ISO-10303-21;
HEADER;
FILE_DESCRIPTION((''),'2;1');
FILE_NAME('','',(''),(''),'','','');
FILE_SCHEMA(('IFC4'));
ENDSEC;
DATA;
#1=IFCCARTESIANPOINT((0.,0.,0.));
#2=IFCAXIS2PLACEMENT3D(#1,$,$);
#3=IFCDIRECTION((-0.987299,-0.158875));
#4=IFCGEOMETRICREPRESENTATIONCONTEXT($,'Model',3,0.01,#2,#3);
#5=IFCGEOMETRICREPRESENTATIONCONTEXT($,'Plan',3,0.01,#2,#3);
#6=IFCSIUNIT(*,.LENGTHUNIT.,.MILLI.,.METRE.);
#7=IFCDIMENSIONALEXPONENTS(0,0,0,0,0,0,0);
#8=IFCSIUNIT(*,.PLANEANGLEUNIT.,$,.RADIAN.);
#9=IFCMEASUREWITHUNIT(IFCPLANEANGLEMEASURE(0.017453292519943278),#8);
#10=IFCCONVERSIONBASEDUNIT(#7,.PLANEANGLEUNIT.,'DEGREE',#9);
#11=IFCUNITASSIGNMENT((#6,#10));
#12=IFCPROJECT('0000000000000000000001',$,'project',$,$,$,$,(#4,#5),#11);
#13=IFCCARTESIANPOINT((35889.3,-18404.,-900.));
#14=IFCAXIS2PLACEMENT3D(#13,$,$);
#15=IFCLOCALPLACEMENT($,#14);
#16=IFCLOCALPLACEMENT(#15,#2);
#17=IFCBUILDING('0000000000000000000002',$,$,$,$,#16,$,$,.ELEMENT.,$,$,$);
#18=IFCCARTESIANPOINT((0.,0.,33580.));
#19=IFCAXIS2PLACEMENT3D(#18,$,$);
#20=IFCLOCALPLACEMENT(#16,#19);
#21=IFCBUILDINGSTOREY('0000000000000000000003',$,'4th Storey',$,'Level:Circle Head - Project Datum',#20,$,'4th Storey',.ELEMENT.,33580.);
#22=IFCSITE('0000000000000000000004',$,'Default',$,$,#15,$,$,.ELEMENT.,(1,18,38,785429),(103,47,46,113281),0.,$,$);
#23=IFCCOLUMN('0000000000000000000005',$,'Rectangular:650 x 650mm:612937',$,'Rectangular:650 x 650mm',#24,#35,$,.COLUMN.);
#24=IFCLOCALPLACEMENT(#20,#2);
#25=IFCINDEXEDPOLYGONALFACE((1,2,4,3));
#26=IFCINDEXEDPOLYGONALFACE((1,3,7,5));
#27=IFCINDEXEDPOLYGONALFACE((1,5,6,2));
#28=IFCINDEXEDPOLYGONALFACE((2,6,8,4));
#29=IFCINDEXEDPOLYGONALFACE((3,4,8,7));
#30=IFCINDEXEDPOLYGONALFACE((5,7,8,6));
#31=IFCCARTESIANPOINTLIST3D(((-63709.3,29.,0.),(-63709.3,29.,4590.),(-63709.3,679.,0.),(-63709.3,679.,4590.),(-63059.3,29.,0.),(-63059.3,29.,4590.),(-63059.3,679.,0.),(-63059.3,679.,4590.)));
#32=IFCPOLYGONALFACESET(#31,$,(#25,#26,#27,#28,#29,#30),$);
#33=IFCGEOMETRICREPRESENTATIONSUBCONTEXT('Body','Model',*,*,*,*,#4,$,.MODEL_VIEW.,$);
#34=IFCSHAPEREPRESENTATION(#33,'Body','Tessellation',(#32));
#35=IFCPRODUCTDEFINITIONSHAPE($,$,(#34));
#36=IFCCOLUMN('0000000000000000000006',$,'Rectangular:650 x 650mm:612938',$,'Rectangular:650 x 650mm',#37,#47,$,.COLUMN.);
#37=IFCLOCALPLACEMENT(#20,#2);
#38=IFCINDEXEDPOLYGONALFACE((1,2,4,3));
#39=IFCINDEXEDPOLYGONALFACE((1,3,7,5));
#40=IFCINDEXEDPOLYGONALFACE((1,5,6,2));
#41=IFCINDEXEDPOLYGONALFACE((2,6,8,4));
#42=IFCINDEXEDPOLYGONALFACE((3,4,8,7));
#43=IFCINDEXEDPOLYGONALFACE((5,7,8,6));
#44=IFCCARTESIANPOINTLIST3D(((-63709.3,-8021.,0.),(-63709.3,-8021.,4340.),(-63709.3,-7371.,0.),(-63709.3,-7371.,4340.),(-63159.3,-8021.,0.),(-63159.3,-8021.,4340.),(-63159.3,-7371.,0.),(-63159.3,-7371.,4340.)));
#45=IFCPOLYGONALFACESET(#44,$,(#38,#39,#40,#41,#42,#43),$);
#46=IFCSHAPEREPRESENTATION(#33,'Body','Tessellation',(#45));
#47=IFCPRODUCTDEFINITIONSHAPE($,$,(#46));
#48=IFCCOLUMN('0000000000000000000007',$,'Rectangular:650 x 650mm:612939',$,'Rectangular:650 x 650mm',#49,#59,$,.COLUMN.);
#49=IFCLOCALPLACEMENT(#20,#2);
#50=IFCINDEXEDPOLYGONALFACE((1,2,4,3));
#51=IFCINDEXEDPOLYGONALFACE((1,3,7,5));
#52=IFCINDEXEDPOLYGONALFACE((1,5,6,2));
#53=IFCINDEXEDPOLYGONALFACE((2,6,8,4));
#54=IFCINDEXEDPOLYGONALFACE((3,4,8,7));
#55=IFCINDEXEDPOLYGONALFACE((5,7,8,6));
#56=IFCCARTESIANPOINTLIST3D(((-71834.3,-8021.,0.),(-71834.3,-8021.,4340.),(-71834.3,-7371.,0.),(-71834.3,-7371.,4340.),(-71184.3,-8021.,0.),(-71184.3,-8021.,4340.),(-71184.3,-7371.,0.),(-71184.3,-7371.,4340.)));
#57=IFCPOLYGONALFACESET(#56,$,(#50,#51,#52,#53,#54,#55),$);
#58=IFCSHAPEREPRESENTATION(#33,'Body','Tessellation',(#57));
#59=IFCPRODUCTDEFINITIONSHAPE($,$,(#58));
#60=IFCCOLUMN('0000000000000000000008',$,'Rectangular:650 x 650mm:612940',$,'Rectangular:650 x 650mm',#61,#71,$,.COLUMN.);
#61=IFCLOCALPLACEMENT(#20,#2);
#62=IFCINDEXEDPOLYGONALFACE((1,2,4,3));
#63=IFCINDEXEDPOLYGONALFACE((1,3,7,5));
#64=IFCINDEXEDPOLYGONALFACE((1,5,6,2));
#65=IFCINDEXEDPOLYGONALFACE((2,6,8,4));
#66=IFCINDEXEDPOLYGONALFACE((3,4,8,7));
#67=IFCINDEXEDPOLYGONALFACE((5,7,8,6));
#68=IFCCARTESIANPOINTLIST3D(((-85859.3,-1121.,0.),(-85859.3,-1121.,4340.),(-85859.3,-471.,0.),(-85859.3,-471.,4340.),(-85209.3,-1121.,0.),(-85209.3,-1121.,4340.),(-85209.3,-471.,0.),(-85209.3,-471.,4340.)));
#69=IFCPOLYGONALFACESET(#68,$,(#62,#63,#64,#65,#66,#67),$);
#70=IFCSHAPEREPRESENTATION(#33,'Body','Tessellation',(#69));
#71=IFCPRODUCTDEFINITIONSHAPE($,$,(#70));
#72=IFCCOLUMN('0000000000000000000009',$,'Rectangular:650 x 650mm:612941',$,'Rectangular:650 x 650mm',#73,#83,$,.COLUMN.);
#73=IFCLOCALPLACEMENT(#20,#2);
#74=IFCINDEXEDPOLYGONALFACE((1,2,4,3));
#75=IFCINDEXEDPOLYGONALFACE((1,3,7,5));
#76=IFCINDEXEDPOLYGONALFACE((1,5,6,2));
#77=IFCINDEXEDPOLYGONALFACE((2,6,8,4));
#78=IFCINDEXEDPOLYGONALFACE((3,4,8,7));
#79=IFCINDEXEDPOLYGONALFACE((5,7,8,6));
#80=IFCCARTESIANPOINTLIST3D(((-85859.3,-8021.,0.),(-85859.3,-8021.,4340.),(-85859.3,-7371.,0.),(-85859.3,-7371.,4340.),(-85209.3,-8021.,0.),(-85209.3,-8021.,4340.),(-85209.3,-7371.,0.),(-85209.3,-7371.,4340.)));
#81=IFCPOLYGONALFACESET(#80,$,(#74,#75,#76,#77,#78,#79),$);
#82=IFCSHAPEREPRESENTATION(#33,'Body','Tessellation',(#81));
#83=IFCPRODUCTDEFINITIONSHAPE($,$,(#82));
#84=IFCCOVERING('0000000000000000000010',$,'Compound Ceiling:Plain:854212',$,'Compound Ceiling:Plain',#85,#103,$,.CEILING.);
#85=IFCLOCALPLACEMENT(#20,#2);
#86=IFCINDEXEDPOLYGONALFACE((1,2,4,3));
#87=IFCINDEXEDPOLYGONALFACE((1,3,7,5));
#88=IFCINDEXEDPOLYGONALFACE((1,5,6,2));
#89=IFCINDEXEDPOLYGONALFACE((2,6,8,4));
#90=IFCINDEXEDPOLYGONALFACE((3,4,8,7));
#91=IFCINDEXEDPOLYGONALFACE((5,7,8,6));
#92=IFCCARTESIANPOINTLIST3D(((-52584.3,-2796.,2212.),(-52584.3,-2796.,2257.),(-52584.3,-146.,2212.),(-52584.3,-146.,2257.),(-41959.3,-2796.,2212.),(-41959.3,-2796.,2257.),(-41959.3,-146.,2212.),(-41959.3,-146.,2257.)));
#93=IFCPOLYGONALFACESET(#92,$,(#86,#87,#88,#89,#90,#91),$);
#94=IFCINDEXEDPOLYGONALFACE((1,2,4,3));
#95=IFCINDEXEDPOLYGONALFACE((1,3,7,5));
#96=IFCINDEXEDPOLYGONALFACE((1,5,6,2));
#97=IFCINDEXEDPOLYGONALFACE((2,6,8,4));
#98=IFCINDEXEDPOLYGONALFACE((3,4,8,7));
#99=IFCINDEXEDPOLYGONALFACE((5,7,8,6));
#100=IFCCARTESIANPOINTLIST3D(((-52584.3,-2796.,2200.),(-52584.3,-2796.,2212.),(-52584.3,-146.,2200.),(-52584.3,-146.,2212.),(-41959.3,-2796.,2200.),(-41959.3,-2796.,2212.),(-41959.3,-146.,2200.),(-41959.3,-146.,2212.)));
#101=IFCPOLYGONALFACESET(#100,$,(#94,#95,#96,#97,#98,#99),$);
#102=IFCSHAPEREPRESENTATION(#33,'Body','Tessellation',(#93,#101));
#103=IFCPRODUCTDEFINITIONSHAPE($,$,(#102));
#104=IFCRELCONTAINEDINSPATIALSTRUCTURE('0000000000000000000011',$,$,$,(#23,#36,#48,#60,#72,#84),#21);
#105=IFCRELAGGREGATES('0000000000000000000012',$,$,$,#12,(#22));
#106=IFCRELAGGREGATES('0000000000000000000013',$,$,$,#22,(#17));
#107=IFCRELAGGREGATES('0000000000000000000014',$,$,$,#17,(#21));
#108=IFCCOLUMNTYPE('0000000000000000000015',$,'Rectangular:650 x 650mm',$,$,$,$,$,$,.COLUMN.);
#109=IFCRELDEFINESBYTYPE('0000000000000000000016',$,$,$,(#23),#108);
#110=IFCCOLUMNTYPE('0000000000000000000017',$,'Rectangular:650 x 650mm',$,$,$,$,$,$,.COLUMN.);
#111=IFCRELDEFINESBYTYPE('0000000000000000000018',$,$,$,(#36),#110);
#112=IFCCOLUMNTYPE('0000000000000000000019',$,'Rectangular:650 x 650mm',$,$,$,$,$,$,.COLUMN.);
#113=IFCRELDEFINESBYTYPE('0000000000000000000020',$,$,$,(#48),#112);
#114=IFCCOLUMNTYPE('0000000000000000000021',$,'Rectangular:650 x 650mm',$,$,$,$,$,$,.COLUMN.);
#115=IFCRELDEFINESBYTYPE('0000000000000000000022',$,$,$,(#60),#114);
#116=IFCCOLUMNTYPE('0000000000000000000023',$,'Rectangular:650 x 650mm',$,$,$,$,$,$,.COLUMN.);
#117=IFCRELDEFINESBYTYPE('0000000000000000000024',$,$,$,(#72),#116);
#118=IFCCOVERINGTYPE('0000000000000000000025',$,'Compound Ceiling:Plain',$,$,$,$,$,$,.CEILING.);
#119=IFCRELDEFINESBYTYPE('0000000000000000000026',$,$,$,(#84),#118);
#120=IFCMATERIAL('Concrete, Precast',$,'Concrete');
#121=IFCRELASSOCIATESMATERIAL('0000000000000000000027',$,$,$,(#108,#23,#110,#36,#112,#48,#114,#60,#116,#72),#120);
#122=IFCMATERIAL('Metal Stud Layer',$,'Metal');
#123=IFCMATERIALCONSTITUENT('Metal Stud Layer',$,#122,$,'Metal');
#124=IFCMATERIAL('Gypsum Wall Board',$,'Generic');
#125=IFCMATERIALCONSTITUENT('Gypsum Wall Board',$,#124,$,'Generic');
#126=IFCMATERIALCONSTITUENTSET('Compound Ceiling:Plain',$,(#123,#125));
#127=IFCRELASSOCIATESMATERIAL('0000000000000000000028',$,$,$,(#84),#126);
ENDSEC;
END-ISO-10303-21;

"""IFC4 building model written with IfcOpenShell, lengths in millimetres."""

from ifc_helpers import new_model, entity, si_unit, converted_unit, direction, frame, origin, place, context, subcontext, project, spatial, indexed_curve, outline, extrude, source, transform, mapped, material, constituent, constituent_set, type_object, type_shapes, element, save


model = new_model("IFC4")

# Units and contexts
model_context = context("Model", 3, precision=0.01, world=origin(), true_north=direction((-0.987299, -0.158875)))
plan_context = context("Plan", 3, precision=0.01, world=origin(), true_north=direction((-0.987299, -0.158875)))
body_context = subcontext(model_context, "Body", "Model", "MODEL_VIEW")
ifc_project = project(units=[si_unit("LENGTHUNIT", "METRE", prefix="MILLI"), converted_unit("PLANEANGLEUNIT", "DEGREE", entity("IfcPlaneAngleMeasure", 0.017453292519943278), si_unit("PLANEANGLEUNIT", "RADIAN"), dimensions=[0, 0, 0, 0, 0, 0, 0])], contexts=[model_context, plan_context])

# Site, building, storey
site_placement = place(None, frame((35889.3, -18404.0, -900.0)))
site = spatial("IfcSite", under=ifc_project, at=site_placement, Name="Default", CompositionType="ELEMENT", RefLatitude=(1, 18, 38, 785429), RefLongitude=(103, 47, 46, 113281), RefElevation=0.0)
building_placement = place(site_placement, origin())
building = spatial("IfcBuilding", under=site, at=building_placement, CompositionType="ELEMENT")
storey_placement = place(building_placement, frame((0.0, 0.0, 33580.0)))
storey = spatial("IfcBuildingStorey", under=building, at=storey_placement, Name="4th Storey", ObjectType="Level:Circle Head - Project Datum", LongName="4th Storey", CompositionType="ELEMENT", Elevation=33580.0)

# Columns
ifc_material_1 = material(Name="Concrete, Precast", Category="Concrete")
column_type_1 = type_object("IfcColumnType", Name="Rectangular:650 x 650mm", PredefinedType="COLUMN", material=ifc_material_1)
shared_shape_1 = source(origin(), body_context, "Body", "SweptSolid", [
    extrude(outline(indexed_curve([(-325.0, -325.0), (325.0, -325.0), (325.0, 325.0), (-325.0, 325.0), (-325.0, -325.0)], self_intersect=False)), frame((-63384.3, 354.0, 33580.0), z_axis=(0.0, 0.0, 1.0), x_axis=(-1.0, 0.0, 0.0)), (0.0, 0.0, 1.0), 4590.0),
])
type_shapes(column_type_1, [shared_shape_1])
column_1_placement = place(storey_placement, frame((0.0, 0.0, -33580.0)))
element("IfcColumn", 1, at=column_1_placement, inside=storey, type_object=column_type_1, material=ifc_material_1, Name="Rectangular:650 x 650mm:612937", ObjectType="Rectangular:650 x 650mm", PredefinedType="COLUMN", context=body_context, shape_type="MappedRepresentation", body=[
    mapped(shared_shape_1, transform((0.0, 0.0, 0.0), scale=1.0)),
])
column_type_2 = type_object("IfcColumnType", Name="Rectangular:650 x 650mm", PredefinedType="COLUMN", material=ifc_material_1)
shared_shape_2 = source(origin(), body_context, "Body", "SweptSolid", [
    extrude(outline(indexed_curve([(-275.0, -325.0), (275.0, -325.0), (275.0, 325.0), (-275.0, 325.0), (-275.0, -325.0)], self_intersect=False)), frame((-63434.3, -7696.0, 33580.0)), (0.0, 0.0, 1.0), 4340.0),
])
type_shapes(column_type_2, [shared_shape_2])
column_2_placement = place(storey_placement, frame((0.0, 0.0, -33580.0)))
element("IfcColumn", 2, at=column_2_placement, inside=storey, type_object=column_type_2, material=ifc_material_1, Name="Rectangular:650 x 650mm:612938", ObjectType="Rectangular:650 x 650mm", PredefinedType="COLUMN", context=body_context, shape_type="MappedRepresentation", body=[
    mapped(shared_shape_2, transform((0.0, 0.0, 0.0), scale=1.0)),
])
column_type_3 = type_object("IfcColumnType", Name="Rectangular:650 x 650mm", PredefinedType="COLUMN", material=ifc_material_1)
shared_shape_3 = source(origin(), body_context, "Body", "SweptSolid", [
    extrude(outline(indexed_curve([(-325.0, -325.0), (325.0, -325.0), (325.0, 325.0), (-325.0, 325.0), (-325.0, -325.0)], self_intersect=False)), frame((-71509.3, -7696.0, 33580.0), z_axis=(0.0, 0.0, 1.0), x_axis=(0.0, -1.0, 0.0)), (0.0, 0.0, 1.0), 4340.0),
])
type_shapes(column_type_3, [shared_shape_3])
column_3_placement = place(storey_placement, frame((0.0, 0.0, -33580.0)))
element("IfcColumn", 3, at=column_3_placement, inside=storey, type_object=column_type_3, material=ifc_material_1, Name="Rectangular:650 x 650mm:612939", ObjectType="Rectangular:650 x 650mm", PredefinedType="COLUMN", context=body_context, shape_type="MappedRepresentation", body=[
    mapped(shared_shape_3, transform((0.0, 0.0, 0.0), scale=1.0)),
])
column_type_4 = type_object("IfcColumnType", Name="Rectangular:650 x 650mm", PredefinedType="COLUMN", material=ifc_material_1)
shared_shape_4 = source(origin(), body_context, "Body", "SweptSolid", [
    extrude(outline(indexed_curve([(-325.0, -325.0), (325.0, -325.0), (325.0, 325.0), (-325.0, 325.0), (-325.0, -325.0)], self_intersect=False)), frame((-85534.3, -796.0, 33580.0), z_axis=(0.0, 0.0, 1.0), x_axis=(0.0, 1.0, 0.0)), (0.0, 0.0, 1.0), 4340.0),
])
type_shapes(column_type_4, [shared_shape_4])
column_4_placement = place(storey_placement, frame((0.0, 0.0, -33580.0)))
element("IfcColumn", 4, at=column_4_placement, inside=storey, type_object=column_type_4, material=ifc_material_1, Name="Rectangular:650 x 650mm:612940", ObjectType="Rectangular:650 x 650mm", PredefinedType="COLUMN", context=body_context, shape_type="MappedRepresentation", body=[
    mapped(shared_shape_4, transform((0.0, 0.0, 0.0), scale=1.0)),
])
column_type_5 = type_object("IfcColumnType", Name="Rectangular:650 x 650mm", PredefinedType="COLUMN", material=ifc_material_1)
shared_shape_5 = source(origin(), body_context, "Body", "SweptSolid", [
    extrude(outline(indexed_curve([(-325.0, -325.0), (325.0, -325.0), (325.0, 325.0), (-325.0, 325.0), (-325.0, -325.0)], self_intersect=False)), frame((-85534.3, -7696.0, 33580.0), z_axis=(0.0, 0.0, 1.0), x_axis=(0.0, 1.0, 0.0)), (0.0, 0.0, 1.0), 4340.0),
])
type_shapes(column_type_5, [shared_shape_5])
column_5_placement = place(storey_placement, frame((0.0, 0.0, -33580.0)))
element("IfcColumn", 5, at=column_5_placement, inside=storey, type_object=column_type_5, material=ifc_material_1, Name="Rectangular:650 x 650mm:612941", ObjectType="Rectangular:650 x 650mm", PredefinedType="COLUMN", context=body_context, shape_type="MappedRepresentation", body=[
    mapped(shared_shape_5, transform((0.0, 0.0, 0.0), scale=1.0)),
])

# Covering
ifc_material_2 = material(Name="Metal Stud Layer", Category="Metal")
ifc_constituent_1 = constituent(ifc_material_2, Name="Metal Stud Layer", Category="Metal")
ifc_material_3 = material(Name="Gypsum Wall Board", Category="Generic")
ifc_constituent_2 = constituent(ifc_material_3, Name="Gypsum Wall Board", Category="Generic")
ifc_constituent_set_1 = constituent_set(constituents=[ifc_constituent_1, ifc_constituent_2], Name="Compound Ceiling:Plain")
covering_type = type_object("IfcCoveringType", Name="Compound Ceiling:Plain", PredefinedType="CEILING")
covering_placement = place(storey_placement, origin())
element("IfcCovering", 6, at=covering_placement, inside=storey, type_object=covering_type, material=ifc_constituent_set_1, Name="Compound Ceiling:Plain:854212", ObjectType="Compound Ceiling:Plain", PredefinedType="CEILING", context=body_context, shape_type="SweptSolid", body=[
    extrude(outline(indexed_curve([(-5312.5, -1325.0), (5312.5, -1325.0), (5312.5, 1325.0), (-5312.5, 1325.0), (-5312.5, -1325.0)], self_intersect=False)), frame((-47271.8, -1471.0, 2212.0), z_axis=(0.0, 0.0, 1.0), x_axis=(-1.0, 0.0, 0.0)), (0.0, 0.0, 1.0), 45.0),
    extrude(outline(indexed_curve([(-1325.0, -5312.5), (1325.0, -5312.5), (1325.0, 5312.5), (-1325.0, 5312.5), (-1325.0, -5312.5)], self_intersect=False)), frame((-47271.8, -1471.0, 2200.0), z_axis=(0.0, 0.0, 1.0), x_axis=(0.0, 1.0, 0.0)), (0.0, 0.0, 1.0), 12.0),
])

save(model, "model.ifc")
